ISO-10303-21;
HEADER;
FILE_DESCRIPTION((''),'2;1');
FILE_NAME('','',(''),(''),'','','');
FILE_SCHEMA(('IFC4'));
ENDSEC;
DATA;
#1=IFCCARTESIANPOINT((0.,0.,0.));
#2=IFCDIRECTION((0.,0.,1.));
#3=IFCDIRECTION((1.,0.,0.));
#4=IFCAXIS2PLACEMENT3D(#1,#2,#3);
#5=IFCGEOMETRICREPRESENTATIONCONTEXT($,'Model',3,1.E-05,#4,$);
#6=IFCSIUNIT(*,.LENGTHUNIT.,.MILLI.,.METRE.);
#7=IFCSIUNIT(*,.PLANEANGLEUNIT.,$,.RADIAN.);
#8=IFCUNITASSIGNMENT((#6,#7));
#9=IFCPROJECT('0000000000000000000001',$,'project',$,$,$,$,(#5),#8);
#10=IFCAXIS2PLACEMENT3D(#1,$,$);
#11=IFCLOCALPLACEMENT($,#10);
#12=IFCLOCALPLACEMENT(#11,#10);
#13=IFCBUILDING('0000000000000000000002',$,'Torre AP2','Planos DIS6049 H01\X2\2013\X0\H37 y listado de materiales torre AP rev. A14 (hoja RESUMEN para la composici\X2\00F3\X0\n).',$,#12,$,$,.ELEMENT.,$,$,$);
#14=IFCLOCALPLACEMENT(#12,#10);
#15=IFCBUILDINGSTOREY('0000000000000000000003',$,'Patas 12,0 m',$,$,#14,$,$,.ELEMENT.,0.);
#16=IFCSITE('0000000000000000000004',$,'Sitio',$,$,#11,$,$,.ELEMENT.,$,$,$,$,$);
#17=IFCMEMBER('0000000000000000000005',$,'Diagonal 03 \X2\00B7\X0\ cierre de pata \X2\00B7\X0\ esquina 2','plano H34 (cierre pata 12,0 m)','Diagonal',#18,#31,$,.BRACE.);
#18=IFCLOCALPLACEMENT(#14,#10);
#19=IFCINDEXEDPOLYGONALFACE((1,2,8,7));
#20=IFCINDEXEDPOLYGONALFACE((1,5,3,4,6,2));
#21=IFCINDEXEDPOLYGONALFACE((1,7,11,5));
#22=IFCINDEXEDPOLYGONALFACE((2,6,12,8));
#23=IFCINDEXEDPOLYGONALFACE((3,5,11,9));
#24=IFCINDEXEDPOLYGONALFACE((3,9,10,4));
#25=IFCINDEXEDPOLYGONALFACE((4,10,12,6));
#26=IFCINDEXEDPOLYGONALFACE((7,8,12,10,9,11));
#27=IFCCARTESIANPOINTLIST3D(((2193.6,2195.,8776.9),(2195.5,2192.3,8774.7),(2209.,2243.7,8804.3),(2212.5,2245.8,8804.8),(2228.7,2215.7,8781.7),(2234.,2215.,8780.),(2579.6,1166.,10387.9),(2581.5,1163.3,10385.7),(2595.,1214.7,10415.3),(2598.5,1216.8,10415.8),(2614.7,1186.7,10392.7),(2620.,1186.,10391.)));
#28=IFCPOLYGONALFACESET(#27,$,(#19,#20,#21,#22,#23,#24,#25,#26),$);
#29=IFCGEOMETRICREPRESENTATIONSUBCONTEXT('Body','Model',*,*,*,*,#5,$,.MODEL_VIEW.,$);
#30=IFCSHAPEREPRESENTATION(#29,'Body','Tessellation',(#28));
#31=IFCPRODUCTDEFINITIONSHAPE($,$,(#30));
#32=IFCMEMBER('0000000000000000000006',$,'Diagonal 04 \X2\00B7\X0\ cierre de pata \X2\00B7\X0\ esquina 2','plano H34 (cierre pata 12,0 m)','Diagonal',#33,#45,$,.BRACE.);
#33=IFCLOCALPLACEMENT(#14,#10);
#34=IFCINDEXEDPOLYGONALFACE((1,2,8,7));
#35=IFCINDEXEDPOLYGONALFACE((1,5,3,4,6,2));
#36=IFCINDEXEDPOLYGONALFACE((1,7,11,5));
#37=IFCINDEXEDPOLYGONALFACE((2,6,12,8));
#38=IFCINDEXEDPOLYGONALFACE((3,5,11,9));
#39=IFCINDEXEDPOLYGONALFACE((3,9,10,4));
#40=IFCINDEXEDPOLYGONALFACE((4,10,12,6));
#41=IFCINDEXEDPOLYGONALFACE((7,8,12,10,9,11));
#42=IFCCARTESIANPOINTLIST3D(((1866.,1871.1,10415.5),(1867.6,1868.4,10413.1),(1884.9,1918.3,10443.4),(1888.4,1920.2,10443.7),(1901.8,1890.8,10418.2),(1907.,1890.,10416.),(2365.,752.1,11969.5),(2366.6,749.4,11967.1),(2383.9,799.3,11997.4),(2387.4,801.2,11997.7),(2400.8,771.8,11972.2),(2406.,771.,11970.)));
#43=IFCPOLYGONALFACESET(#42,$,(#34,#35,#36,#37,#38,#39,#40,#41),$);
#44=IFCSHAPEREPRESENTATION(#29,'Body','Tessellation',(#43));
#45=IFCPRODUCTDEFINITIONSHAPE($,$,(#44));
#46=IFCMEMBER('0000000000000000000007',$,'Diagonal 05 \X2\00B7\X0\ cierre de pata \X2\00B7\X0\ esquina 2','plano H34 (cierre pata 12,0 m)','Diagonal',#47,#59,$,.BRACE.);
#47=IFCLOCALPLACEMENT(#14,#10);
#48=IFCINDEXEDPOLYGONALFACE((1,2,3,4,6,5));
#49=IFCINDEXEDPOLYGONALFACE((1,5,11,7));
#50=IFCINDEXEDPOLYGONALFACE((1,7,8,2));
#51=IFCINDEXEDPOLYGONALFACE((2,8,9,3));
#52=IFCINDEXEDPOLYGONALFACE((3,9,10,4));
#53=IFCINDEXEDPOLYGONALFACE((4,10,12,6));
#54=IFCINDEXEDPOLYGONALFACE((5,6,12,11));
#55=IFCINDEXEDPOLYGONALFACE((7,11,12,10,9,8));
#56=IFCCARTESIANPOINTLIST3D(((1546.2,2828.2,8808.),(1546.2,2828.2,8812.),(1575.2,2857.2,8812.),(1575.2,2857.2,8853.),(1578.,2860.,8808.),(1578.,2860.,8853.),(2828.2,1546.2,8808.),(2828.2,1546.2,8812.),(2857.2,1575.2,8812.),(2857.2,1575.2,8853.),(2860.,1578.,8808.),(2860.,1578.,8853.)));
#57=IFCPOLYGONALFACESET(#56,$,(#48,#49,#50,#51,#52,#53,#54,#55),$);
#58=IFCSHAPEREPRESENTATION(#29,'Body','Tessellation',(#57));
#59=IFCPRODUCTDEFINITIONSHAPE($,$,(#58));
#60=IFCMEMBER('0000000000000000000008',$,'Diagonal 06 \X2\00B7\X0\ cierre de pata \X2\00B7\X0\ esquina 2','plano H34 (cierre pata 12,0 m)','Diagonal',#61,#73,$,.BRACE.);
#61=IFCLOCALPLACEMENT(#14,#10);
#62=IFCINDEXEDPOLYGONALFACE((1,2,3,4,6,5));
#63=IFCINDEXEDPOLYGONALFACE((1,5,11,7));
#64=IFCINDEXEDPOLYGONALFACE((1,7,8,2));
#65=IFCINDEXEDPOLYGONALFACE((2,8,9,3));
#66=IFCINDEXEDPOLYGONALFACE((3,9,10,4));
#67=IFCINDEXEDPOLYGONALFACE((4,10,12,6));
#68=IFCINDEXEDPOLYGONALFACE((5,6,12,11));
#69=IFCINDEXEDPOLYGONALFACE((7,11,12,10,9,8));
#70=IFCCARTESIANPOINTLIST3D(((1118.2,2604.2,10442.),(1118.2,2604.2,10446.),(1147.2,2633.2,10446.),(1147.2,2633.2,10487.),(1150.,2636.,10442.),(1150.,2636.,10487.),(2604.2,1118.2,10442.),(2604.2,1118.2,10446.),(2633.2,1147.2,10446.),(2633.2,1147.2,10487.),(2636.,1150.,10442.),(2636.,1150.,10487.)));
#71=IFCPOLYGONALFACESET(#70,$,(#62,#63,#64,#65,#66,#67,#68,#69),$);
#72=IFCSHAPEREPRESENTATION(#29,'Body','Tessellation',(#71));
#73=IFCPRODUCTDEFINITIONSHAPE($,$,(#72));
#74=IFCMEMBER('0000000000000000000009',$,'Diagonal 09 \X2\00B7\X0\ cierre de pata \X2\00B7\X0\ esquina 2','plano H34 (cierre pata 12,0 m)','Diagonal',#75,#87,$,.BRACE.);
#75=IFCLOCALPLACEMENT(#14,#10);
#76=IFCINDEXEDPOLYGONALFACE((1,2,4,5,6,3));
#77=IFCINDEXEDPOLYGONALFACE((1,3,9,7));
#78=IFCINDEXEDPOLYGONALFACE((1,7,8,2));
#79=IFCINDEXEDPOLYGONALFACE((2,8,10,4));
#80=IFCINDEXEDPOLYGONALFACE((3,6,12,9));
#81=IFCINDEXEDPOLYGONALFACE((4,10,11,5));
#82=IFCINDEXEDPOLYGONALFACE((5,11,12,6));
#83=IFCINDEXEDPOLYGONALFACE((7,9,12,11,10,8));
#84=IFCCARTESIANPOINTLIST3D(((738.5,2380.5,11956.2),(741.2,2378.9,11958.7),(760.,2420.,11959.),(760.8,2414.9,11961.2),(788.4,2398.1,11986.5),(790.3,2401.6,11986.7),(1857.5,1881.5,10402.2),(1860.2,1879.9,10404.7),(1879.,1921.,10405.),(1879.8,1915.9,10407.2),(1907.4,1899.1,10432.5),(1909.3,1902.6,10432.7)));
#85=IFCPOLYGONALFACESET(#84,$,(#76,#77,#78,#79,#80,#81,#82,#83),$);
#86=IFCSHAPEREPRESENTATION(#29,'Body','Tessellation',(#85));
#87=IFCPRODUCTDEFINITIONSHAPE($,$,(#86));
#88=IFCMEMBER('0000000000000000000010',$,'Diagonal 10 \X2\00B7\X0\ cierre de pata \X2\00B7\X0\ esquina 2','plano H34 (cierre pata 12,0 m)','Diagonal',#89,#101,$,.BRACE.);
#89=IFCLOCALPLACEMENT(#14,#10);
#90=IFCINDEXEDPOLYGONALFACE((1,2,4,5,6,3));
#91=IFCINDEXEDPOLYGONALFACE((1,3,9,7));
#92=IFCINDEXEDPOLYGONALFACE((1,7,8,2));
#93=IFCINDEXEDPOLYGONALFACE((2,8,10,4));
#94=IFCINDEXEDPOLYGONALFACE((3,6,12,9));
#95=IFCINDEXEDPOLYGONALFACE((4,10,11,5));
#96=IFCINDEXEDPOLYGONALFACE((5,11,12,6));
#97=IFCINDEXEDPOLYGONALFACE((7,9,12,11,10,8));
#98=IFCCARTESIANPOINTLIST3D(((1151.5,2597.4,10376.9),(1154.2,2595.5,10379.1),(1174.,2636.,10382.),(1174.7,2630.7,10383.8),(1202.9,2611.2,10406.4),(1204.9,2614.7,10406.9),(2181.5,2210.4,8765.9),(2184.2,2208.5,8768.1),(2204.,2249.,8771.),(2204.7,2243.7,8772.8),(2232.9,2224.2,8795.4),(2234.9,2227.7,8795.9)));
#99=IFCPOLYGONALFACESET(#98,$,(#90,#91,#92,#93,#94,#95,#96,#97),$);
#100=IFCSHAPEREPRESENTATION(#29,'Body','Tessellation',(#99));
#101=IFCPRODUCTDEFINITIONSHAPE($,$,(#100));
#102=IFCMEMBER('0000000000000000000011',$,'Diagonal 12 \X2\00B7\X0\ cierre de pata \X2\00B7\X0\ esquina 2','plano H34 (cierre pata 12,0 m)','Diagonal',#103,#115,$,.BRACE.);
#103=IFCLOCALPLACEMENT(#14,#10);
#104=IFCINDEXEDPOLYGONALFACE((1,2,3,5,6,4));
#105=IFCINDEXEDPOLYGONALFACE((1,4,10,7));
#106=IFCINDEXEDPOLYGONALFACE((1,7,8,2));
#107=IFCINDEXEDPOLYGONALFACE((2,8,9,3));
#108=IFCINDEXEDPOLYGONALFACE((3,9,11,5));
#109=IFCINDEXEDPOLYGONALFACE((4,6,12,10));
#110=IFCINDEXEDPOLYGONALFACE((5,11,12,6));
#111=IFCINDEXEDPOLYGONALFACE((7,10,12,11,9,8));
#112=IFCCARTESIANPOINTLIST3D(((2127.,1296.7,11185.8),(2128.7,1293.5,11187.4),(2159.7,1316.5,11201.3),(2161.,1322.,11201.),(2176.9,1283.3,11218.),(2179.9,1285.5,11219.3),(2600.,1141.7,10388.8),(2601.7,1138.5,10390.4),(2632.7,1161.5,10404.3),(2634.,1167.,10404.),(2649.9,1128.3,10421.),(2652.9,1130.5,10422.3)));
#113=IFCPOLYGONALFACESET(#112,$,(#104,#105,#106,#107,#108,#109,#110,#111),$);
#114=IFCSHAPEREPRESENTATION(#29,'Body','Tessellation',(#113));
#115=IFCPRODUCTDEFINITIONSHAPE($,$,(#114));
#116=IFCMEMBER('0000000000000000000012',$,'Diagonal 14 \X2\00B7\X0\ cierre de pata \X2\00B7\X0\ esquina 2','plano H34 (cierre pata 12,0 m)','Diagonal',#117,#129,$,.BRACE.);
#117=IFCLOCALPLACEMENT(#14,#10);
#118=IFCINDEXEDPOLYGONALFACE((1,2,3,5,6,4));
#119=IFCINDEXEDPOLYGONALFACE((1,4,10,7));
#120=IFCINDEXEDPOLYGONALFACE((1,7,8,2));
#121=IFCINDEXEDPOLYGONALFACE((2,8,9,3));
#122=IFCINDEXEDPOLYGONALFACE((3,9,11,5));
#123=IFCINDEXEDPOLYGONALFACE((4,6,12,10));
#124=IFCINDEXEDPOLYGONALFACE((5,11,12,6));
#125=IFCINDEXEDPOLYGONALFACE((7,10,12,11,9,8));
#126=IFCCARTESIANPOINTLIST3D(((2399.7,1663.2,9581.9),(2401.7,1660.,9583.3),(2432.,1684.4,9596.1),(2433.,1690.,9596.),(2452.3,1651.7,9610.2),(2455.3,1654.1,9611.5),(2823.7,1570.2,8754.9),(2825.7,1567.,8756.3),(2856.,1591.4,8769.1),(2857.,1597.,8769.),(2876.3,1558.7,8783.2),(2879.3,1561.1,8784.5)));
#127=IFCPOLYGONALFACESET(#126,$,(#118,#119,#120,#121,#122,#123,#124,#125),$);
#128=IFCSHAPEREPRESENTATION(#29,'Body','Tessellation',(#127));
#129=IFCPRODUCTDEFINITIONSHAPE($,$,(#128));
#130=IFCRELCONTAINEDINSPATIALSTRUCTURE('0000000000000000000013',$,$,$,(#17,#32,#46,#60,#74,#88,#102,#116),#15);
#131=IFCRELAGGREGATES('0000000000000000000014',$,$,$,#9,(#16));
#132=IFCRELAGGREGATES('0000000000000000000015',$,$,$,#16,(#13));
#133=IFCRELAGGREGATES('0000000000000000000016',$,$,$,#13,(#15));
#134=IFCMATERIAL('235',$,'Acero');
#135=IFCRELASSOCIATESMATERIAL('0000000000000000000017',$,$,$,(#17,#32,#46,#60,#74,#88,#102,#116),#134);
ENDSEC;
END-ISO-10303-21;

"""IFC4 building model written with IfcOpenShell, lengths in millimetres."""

from ifc_helpers import new_model, si_unit, frame, frame_2d, origin, origin_with_axes, place, context, subcontext, project, spatial, l_section, extrude, material, element, save


model = new_model("IFC4")

# Units and contexts
model_context = context("Model", 3, precision=1e-05, world=origin_with_axes())
body_context = subcontext(model_context, "Body", "Model", "MODEL_VIEW")
ifc_project = project(units=[si_unit("LENGTHUNIT", "METRE", prefix="MILLI"), si_unit("PLANEANGLEUNIT", "RADIAN")], contexts=[model_context])

# Site, building, storey
site_placement = place(None, origin())
site = spatial("IfcSite", under=ifc_project, at=site_placement, Name="Sitio", CompositionType="ELEMENT")
building_placement = place(site_placement, origin())
building = spatial("IfcBuilding", under=site, at=building_placement, Name="Torre AP2", Description="Planos DIS6049 H01–H37 y listado de materiales torre AP rev. A14 (hoja RESUMEN para la composición).", CompositionType="ELEMENT")
storey_placement = place(building_placement, origin())
storey = spatial("IfcBuildingStorey", under=building, at=storey_placement, Name="Patas 12,0 m", CompositionType="ELEMENT", Elevation=0.0)

# Members
ifc_material_1 = material(Name="235", Category="Acero")
member_1_placement = place(storey_placement, frame((2620.0, 1186.0, 10391.0), z_axis=(-0.197932, 0.527647, -0.826082), x_axis=(-0.855328, -0.504616, -0.117376)))
element("IfcMember", 1, at=member_1_placement, inside=storey, material=ifc_material_1, Name="Diagonal 03 · cierre de pata · esquina 2", Description="plano H34 (cierre pata 12,0 m)", ObjectType="Diagonal", PredefinedType="BRACE", context=body_context, shape_type="SweptSolid", body=[
    extrude(l_section(Depth=45.0, Width=45.0, Thickness=4.0, at=frame_2d((22.5, 22.5))), None, (0.0, 0.0, 1.0), 1950.2),
])
member_2_placement = place(storey_placement, frame((2406.0, 771.0, 11970.0), z_axis=(-0.252159, 0.565463, -0.785281), x_axis=(-0.874778, -0.480163, -0.064857)))
element("IfcMember", 2, at=member_2_placement, inside=storey, material=ifc_material_1, Name="Diagonal 04 · cierre de pata · esquina 2", Description="plano H34 (cierre pata 12,0 m)", ObjectType="Diagonal", PredefinedType="BRACE", context=body_context, shape_type="SweptSolid", body=[
    extrude(l_section(Depth=45.0, Width=45.0, Thickness=4.0, at=frame_2d((22.5, 22.5))), None, (0.0, 0.0, 1.0), 1978.9),
])
member_3_placement = place(storey_placement, frame((2860.0, 1578.0, 8808.0), z_axis=(-0.707107, 0.707107, 0.0), x_axis=(-0.707107, -0.707107, 0.0)))
element("IfcMember", 3, at=member_3_placement, inside=storey, material=ifc_material_1, Name="Diagonal 05 · cierre de pata · esquina 2", Description="plano H34 (cierre pata 12,0 m)", ObjectType="Diagonal", PredefinedType="BRACE", context=body_context, shape_type="SweptSolid", body=[
    extrude(l_section(Depth=45.0, Width=45.0, Thickness=4.0, at=frame_2d((22.5, 22.5))), None, (0.0, 0.0, 1.0), 1813.0),
])
member_4_placement = place(storey_placement, frame((2636.0, 1150.0, 10442.0), z_axis=(-0.707107, 0.707107, 0.0), x_axis=(-0.707107, -0.707107, 0.0)))
element("IfcMember", 4, at=member_4_placement, inside=storey, material=ifc_material_1, Name="Diagonal 06 · cierre de pata · esquina 2", Description="plano H34 (cierre pata 12,0 m)", ObjectType="Diagonal", PredefinedType="BRACE", context=body_context, shape_type="SweptSolid", body=[
    extrude(l_section(Depth=45.0, Width=45.0, Thickness=4.0, at=frame_2d((22.5, 22.5))), None, (0.0, 0.0, 1.0), 2101.5),
])
member_5_placement = place(storey_placement, frame((1879.0, 1921.0, 10405.0), z_axis=(-0.565463, 0.252159, 0.785281), x_axis=(-0.476669, -0.876918, -0.061654)))
element("IfcMember", 5, at=member_5_placement, inside=storey, material=ifc_material_1, Name="Diagonal 09 · cierre de pata · esquina 2", Description="plano H34 (cierre pata 12,0 m)", ObjectType="Diagonal", PredefinedType="BRACE", context=body_context, shape_type="SweptSolid", body=[
    extrude(l_section(Depth=45.0, Width=45.0, Thickness=4.0, at=frame_2d((22.5, 22.5))), None, (0.0, 0.0, 1.0), 1978.9),
])
member_6_placement = place(storey_placement, frame((2204.0, 2249.0, 8771.0), z_axis=(-0.527963, 0.198371, 0.825775), x_axis=(-0.5011, -0.857806, -0.114315)))
element("IfcMember", 6, at=member_6_placement, inside=storey, material=ifc_material_1, Name="Diagonal 10 · cierre de pata · esquina 2", Description="plano H34 (cierre pata 12,0 m)", ObjectType="Diagonal", PredefinedType="BRACE", context=body_context, shape_type="SweptSolid", body=[
    extrude(l_section(Depth=45.0, Width=45.0, Thickness=4.0, at=frame_2d((22.5, 22.5))), None, (0.0, 0.0, 1.0), 1950.9),
])
member_7_placement = place(storey_placement, frame((2634.0, 1167.0, 10404.0), z_axis=(-0.503373, 0.164953, 0.848178), x_axis=(-0.754706, -0.561924, -0.338617)))
element("IfcMember", 7, at=member_7_placement, inside=storey, material=ifc_material_1, Name="Diagonal 12 · cierre de pata · esquina 2", Description="plano H34 (cierre pata 12,0 m)", ObjectType="Diagonal", PredefinedType="BRACE", context=body_context, shape_type="SweptSolid", body=[
    extrude(l_section(Depth=45.0, Width=45.0, Thickness=4.0, at=frame_2d((22.5, 22.5))), None, (0.0, 0.0, 1.0), 939.7),
])
member_8_placement = place(storey_placement, frame((2857.0, 1597.0, 8769.0), z_axis=(-0.453962, 0.099572, 0.88544), x_axis=(-0.740469, -0.594896, -0.312737)))
element("IfcMember", 8, at=member_8_placement, inside=storey, material=ifc_material_1, Name="Diagonal 14 · cierre de pata · esquina 2", Description="plano H34 (cierre pata 12,0 m)", ObjectType="Diagonal", PredefinedType="BRACE", context=body_context, shape_type="SweptSolid", body=[
    extrude(l_section(Depth=45.0, Width=45.0, Thickness=4.0, at=frame_2d((22.5, 22.5))), None, (0.0, 0.0, 1.0), 934.0),
])

save(model, "model.ifc")
